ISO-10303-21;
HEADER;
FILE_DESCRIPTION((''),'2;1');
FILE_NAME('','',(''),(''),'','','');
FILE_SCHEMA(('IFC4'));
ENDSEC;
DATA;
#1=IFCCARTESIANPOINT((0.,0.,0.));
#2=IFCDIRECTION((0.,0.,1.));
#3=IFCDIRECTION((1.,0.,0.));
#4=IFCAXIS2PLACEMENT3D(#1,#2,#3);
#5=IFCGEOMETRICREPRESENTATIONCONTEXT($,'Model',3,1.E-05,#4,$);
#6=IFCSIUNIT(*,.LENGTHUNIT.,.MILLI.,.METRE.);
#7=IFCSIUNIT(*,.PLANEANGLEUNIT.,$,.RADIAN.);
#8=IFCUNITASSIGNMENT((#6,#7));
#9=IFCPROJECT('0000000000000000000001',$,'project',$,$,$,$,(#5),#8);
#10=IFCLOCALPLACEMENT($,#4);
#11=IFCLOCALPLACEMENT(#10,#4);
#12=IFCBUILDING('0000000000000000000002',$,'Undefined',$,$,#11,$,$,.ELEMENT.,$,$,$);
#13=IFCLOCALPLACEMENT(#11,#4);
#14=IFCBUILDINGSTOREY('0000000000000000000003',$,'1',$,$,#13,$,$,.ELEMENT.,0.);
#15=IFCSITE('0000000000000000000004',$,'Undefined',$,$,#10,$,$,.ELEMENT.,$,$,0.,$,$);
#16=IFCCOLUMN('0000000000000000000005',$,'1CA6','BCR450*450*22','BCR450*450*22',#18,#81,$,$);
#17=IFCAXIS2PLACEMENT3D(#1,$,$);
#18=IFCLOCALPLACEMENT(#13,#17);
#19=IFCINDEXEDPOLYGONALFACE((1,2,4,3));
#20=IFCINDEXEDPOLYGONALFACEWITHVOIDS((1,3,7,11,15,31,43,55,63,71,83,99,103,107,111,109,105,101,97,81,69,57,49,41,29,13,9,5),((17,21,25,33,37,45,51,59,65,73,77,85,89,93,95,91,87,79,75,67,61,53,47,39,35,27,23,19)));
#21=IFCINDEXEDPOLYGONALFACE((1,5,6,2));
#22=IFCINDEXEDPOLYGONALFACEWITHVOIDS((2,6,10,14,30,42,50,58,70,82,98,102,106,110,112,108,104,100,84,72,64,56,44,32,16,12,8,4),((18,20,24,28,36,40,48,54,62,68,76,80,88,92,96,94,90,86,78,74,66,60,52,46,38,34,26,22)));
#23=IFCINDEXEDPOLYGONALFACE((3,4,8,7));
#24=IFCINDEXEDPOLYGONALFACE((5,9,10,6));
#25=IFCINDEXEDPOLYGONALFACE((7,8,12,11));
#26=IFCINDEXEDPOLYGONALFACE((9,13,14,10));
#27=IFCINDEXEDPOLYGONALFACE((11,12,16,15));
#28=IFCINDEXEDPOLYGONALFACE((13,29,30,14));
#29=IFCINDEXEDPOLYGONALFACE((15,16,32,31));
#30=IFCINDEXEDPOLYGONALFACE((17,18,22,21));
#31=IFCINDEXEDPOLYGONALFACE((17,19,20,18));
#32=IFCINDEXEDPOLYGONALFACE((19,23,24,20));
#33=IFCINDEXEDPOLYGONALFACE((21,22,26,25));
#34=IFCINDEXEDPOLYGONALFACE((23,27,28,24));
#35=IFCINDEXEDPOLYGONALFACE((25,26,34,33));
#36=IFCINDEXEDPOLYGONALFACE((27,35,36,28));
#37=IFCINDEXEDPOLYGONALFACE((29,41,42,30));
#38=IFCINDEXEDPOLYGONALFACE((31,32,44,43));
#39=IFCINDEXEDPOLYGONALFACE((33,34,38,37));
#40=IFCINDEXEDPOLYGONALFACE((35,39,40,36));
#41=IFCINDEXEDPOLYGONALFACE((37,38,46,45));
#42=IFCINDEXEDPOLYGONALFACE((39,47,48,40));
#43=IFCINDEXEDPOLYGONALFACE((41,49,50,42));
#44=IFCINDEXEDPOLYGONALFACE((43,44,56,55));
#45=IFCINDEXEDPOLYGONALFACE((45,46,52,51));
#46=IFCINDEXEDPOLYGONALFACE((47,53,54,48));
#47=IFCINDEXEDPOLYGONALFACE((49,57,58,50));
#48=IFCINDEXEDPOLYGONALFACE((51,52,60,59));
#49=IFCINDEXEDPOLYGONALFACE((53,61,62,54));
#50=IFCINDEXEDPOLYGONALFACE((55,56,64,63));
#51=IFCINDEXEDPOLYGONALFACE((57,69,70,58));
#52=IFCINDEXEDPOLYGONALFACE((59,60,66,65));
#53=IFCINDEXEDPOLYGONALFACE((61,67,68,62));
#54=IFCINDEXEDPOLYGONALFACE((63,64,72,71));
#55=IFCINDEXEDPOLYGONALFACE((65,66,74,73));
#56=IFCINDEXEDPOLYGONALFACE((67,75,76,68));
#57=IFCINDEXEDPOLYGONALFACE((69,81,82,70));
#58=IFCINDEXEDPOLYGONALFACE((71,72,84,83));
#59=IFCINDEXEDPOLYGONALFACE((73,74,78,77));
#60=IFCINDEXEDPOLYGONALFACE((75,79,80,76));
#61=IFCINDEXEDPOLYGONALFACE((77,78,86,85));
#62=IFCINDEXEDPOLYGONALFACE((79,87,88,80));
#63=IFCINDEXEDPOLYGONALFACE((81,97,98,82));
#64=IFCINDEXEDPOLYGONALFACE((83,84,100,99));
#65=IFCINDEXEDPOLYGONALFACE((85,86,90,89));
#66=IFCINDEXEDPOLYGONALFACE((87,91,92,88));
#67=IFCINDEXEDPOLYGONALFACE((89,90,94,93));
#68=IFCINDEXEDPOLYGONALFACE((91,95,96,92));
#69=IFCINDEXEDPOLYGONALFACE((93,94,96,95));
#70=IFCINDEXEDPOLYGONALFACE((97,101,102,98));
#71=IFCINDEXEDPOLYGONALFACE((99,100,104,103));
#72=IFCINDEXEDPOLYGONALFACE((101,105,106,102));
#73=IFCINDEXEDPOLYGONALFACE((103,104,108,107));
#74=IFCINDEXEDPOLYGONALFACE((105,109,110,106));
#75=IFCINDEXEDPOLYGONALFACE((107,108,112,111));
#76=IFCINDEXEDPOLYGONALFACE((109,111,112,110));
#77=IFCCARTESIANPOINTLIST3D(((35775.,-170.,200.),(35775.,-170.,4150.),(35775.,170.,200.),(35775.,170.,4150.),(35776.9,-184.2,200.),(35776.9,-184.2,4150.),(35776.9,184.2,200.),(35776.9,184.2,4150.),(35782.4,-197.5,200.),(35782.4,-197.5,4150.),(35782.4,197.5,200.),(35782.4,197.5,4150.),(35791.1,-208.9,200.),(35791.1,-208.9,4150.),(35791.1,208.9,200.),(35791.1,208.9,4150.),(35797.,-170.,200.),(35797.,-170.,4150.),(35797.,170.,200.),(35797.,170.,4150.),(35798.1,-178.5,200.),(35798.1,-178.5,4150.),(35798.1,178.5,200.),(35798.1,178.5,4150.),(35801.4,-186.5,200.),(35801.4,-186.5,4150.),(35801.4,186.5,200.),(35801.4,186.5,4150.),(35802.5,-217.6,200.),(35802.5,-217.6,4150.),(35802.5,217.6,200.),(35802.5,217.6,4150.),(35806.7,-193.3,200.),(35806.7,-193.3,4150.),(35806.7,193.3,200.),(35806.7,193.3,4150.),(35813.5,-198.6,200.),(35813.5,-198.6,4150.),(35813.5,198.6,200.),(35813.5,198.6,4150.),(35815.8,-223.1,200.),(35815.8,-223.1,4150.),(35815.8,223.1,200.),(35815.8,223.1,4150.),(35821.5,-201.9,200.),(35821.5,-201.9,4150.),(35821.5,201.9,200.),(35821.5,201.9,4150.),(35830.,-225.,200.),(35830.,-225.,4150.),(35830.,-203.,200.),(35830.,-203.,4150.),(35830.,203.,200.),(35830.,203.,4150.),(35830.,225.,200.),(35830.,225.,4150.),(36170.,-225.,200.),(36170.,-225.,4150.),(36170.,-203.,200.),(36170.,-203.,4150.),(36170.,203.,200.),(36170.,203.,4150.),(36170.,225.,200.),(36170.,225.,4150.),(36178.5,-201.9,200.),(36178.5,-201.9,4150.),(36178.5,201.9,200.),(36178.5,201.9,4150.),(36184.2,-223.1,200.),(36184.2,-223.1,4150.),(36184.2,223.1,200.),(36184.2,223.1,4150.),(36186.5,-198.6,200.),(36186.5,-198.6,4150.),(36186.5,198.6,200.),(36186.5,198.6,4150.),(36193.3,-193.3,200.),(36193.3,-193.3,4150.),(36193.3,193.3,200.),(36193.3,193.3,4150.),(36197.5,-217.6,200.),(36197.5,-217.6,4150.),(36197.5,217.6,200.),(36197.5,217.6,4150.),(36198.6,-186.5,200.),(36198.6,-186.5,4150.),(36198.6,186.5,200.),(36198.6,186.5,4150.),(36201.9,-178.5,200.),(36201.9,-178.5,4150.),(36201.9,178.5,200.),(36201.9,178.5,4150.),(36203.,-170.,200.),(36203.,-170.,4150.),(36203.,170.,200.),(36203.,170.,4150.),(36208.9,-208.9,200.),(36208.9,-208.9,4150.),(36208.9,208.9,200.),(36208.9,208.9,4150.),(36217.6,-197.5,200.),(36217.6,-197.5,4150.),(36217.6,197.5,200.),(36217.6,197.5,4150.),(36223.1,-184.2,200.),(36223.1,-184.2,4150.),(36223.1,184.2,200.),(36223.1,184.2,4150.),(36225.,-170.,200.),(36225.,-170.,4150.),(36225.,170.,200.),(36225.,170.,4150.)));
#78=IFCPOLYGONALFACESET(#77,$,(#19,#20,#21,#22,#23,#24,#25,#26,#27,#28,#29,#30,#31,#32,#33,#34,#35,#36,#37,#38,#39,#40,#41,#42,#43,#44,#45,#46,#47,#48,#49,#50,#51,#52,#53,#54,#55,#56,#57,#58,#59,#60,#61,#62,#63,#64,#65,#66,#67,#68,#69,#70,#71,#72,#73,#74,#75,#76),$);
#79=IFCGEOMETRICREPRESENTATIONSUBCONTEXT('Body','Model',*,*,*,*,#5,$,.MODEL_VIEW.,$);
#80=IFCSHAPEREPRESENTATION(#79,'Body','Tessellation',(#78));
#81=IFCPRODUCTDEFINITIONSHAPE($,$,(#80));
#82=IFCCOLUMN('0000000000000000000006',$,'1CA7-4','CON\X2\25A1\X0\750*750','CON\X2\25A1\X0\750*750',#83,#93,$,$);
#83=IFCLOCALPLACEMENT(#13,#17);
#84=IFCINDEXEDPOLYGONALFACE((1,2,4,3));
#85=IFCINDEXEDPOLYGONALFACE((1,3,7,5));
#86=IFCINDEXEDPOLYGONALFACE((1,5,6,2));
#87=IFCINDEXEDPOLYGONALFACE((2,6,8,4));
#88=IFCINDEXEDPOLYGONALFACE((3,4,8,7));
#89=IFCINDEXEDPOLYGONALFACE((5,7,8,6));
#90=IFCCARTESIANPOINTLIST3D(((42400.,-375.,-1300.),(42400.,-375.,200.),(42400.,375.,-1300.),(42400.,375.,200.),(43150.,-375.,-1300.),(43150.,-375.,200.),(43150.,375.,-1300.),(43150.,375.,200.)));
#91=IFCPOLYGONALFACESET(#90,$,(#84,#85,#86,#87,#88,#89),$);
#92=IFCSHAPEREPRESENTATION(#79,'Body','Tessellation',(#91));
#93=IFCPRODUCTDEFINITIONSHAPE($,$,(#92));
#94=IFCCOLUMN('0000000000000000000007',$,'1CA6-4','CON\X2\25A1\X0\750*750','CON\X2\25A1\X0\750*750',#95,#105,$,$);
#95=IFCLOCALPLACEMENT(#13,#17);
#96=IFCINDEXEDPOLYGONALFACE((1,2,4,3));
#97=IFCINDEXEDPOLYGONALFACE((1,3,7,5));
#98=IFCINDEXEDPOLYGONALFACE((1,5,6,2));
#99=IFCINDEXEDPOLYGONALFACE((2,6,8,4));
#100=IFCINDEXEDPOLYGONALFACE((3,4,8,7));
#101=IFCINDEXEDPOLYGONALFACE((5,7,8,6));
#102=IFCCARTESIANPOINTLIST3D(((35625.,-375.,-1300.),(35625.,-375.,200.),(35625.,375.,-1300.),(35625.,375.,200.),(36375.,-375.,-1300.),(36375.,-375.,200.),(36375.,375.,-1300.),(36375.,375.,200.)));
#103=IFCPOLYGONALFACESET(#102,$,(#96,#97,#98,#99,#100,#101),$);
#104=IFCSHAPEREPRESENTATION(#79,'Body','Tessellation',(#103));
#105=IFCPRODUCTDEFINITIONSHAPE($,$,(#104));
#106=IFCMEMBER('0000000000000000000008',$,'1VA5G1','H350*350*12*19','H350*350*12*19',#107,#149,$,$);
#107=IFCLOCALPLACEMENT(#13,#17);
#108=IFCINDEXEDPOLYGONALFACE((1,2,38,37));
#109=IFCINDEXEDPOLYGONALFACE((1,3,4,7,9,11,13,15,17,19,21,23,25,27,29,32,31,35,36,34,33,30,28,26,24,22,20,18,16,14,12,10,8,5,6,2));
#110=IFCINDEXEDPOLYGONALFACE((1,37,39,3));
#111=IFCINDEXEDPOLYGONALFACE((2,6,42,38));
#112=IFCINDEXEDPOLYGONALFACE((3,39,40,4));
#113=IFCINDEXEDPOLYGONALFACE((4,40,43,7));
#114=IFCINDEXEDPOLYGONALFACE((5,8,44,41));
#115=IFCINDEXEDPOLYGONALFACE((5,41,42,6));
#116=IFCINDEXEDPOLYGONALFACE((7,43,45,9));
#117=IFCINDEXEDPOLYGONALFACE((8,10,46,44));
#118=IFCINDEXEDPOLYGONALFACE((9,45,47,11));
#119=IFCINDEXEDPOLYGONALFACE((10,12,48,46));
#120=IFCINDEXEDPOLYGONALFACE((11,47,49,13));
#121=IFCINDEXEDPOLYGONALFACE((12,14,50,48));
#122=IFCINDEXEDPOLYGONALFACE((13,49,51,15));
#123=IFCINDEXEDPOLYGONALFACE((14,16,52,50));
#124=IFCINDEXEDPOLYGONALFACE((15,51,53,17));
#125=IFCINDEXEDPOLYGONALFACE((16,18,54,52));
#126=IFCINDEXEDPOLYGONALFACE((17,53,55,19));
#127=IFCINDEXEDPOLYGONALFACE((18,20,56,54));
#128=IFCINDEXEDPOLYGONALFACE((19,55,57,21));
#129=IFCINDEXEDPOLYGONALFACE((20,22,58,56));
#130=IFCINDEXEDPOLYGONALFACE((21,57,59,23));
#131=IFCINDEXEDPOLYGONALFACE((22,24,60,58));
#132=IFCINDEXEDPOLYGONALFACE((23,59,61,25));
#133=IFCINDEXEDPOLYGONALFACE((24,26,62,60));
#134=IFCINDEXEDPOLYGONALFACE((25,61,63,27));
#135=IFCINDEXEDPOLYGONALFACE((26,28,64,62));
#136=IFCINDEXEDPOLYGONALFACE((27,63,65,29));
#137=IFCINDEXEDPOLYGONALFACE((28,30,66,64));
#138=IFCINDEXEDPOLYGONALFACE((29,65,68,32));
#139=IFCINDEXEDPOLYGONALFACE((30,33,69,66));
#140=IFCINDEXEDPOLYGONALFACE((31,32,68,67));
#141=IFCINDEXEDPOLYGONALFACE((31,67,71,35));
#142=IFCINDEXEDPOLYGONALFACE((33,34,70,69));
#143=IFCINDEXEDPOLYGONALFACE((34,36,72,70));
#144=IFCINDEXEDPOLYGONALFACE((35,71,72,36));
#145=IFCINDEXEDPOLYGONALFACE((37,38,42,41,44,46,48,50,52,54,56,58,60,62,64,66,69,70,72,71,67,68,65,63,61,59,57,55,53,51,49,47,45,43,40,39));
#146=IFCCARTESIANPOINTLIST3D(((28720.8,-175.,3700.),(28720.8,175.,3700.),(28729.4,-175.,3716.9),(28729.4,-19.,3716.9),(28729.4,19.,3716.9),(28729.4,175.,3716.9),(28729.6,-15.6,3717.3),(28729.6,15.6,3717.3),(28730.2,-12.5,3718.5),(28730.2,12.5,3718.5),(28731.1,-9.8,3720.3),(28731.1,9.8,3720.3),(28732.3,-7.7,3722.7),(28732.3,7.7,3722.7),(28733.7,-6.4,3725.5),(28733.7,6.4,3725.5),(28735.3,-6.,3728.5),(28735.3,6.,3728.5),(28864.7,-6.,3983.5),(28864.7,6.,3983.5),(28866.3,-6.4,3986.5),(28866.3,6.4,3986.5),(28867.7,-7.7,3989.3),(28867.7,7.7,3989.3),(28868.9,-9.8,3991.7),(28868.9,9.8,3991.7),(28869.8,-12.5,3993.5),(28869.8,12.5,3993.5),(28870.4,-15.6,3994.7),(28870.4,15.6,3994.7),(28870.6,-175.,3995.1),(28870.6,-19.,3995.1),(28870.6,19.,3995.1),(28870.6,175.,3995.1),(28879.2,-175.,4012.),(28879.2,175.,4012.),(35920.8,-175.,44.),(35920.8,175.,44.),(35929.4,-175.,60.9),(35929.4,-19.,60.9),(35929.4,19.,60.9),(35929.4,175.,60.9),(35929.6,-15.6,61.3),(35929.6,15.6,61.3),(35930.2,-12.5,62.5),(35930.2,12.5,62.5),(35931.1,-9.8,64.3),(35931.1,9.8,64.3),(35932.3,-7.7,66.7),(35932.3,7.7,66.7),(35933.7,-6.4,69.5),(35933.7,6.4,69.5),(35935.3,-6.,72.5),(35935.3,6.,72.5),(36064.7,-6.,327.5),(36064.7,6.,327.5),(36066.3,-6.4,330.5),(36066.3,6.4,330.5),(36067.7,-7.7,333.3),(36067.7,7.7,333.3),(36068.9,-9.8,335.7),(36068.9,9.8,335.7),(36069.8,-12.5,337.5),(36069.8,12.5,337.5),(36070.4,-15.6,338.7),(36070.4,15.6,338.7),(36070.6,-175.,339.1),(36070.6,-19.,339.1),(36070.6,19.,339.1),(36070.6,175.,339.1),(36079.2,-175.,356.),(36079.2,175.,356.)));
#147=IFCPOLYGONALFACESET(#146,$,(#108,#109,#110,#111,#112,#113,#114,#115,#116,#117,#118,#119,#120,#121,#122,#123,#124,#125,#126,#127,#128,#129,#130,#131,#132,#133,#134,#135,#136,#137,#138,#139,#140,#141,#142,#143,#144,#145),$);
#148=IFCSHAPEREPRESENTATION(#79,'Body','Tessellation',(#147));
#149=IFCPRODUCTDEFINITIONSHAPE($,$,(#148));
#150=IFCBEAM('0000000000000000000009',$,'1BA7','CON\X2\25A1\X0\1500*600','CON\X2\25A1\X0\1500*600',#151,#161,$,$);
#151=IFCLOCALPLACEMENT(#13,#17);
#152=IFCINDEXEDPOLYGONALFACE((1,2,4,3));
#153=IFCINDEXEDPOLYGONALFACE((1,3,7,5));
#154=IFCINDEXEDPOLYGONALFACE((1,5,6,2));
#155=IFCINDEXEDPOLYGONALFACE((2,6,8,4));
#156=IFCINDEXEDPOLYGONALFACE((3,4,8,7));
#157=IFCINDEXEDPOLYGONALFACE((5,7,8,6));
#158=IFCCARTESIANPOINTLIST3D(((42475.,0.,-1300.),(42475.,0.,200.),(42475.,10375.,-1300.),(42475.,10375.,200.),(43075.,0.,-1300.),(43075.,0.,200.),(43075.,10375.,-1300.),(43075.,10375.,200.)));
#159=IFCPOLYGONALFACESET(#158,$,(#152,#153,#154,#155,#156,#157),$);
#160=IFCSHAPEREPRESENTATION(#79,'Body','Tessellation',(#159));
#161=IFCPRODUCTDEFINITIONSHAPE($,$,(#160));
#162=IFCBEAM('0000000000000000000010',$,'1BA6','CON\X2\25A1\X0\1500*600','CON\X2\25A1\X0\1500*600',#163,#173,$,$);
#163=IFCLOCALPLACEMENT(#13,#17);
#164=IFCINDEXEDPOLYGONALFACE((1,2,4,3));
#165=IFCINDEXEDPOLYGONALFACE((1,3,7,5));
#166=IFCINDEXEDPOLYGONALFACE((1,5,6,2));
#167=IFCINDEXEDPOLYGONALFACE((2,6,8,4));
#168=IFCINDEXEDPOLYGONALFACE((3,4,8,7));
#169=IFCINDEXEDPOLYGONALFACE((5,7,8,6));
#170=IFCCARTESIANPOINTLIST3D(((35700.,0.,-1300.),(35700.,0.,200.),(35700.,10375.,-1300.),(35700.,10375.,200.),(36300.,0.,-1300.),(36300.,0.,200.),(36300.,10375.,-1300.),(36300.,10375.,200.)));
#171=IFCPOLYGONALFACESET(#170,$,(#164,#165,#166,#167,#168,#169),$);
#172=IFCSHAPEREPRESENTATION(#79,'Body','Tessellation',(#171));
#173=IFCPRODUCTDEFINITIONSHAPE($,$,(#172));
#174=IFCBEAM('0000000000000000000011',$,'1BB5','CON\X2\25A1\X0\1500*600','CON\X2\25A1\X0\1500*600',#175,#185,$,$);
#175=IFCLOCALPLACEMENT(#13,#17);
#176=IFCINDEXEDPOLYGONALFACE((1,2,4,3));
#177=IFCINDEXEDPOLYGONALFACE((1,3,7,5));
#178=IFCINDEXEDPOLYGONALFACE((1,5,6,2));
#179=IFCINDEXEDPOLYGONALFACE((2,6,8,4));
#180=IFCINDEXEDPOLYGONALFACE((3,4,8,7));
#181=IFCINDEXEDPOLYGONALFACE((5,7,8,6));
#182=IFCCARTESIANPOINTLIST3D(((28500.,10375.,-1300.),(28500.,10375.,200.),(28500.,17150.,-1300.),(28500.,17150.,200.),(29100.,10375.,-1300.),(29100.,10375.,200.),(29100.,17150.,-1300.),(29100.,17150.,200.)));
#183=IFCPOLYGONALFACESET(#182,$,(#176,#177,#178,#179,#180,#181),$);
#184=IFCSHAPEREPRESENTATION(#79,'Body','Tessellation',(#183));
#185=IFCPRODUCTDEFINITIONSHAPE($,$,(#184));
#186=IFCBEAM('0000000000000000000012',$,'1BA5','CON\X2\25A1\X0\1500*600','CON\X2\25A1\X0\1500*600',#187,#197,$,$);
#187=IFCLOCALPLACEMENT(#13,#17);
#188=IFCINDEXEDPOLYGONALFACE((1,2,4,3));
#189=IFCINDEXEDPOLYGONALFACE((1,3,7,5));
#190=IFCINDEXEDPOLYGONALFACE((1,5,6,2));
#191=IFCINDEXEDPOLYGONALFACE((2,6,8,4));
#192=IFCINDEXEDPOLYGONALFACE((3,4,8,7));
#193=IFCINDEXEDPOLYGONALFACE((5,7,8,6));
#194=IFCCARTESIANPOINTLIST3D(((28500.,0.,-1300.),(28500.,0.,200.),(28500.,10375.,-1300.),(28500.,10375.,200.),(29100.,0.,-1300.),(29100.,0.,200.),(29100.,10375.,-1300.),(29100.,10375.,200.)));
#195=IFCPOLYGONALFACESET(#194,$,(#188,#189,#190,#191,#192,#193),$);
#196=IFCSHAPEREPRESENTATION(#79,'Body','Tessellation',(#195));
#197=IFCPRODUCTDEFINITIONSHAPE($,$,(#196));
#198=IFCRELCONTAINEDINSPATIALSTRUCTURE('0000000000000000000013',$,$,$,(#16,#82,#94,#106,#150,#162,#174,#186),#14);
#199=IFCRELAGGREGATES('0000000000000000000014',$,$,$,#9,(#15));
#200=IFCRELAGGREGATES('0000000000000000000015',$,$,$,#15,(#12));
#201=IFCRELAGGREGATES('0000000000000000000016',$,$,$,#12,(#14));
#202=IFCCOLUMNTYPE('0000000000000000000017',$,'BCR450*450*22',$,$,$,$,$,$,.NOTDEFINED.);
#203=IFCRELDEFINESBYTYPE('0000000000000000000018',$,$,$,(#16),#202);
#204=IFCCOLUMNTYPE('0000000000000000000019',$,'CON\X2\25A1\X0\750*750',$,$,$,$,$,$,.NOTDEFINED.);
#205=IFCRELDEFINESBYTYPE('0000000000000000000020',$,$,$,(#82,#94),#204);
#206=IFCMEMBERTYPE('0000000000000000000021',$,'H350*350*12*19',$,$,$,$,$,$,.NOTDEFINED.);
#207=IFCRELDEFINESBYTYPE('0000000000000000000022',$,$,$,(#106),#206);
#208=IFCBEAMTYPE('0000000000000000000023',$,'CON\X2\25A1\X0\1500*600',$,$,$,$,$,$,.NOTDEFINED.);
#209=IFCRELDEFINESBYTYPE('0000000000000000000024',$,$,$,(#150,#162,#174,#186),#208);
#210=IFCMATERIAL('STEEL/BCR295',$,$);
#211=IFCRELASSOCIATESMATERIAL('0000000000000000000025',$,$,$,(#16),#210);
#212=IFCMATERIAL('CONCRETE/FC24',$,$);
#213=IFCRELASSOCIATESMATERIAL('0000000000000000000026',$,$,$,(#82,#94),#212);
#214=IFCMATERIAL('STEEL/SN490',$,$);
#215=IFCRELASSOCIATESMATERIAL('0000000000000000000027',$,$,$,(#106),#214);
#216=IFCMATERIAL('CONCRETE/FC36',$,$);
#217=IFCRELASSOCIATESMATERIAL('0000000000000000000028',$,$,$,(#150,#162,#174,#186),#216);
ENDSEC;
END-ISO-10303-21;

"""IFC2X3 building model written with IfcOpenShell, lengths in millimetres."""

from ifc_helpers import new_model, si_unit, frame, origin_with_axes, origin_2d_with_axis, place, context, subcontext, project, spatial, rectangle, hollow_rectangle, i_section, extrude, material, type_object, element, save


model = new_model("IFC2X3")

# Units and contexts
model_context = context("Model", 3, precision=1e-05, world=origin_with_axes())
body_context = subcontext(model_context, "Body", "Model", "MODEL_VIEW")
ifc_project = project(units=[si_unit("LENGTHUNIT", "METRE", prefix="MILLI"), si_unit("PLANEANGLEUNIT", "RADIAN")], contexts=[model_context])

# Site, building, storey
site_placement = place(None, origin_with_axes())
site = spatial("IfcSite", under=ifc_project, at=site_placement, Name="Undefined", CompositionType="ELEMENT", RefElevation=0.0)
building_placement = place(site_placement, origin_with_axes())
building = spatial("IfcBuilding", under=site, at=building_placement, Name="Undefined", CompositionType="ELEMENT")
storey_placement = place(building_placement, origin_with_axes())
storey = spatial("IfcBuildingStorey", under=building, at=storey_placement, Name="1", CompositionType="ELEMENT", Elevation=0.0)

# Shared definitions
ifc_material_1 = material(Name="CONCRETE/FC24")

# Columns
ifc_material_2 = material(Name="STEEL/SN490")
ifc_material_3 = material(Name="STEEL/BCR295")
column_type_1 = type_object("IfcColumnType", Name="BCR450*450*22", PredefinedType="NOTDEFINED")
for number, where, z_axis, x_axis, name in (
    (1, (36000.0, 0.0, 200.0), (0.0, 0.0, 1.0), (0.0, 1.0, 0.0), "1CA6"),
):
    element("IfcColumn", number, at=place(storey_placement, frame(where, z_axis=z_axis, x_axis=x_axis)), inside=storey, type_object=column_type_1, material=ifc_material_3, Name=name, Description="BCR450*450*22", ObjectType="BCR450*450*22", context=body_context, shape_type="SweptSolid", body=[
        extrude(hollow_rectangle(XDim=450.0, YDim=450.0, WallThickness=22.0, InnerFilletRadius=33.0, OuterFilletRadius=55.0, at=origin_2d_with_axis()), frame((0.0, 0.0, 3950.0), z_axis=(0.0, 0.0, -1.0), x_axis=(0.0, 1.0, 0.0)), (0.0, 0.0, 1.0), 3950.0),
    ])
column_type_2 = type_object("IfcColumnType", Name="CON□750*750", PredefinedType="NOTDEFINED")
for number, where, z_axis, x_axis, name in (
    (2, (42775.0, 0.0, -1300.0), (0.0, 0.0, 1.0), (0.0, 1.0, 0.0), "1CA7-4"),
    (3, (36000.0, 0.0, -1300.0), (0.0, 0.0, 1.0), (0.0, 1.0, 0.0), "1CA6-4"),
):
    element("IfcColumn", number, at=place(storey_placement, frame(where, z_axis=z_axis, x_axis=x_axis)), inside=storey, type_object=column_type_2, material=ifc_material_1, Name=name, Description="CON□750*750", ObjectType="CON□750*750", context=body_context, shape_type="SweptSolid", body=[
        extrude(rectangle(XDim=750.0, YDim=750.0, at=origin_2d_with_axis()), frame((0.0, 0.0, 1500.0), z_axis=(0.0, 0.0, -1.0), x_axis=(0.0, 1.0, 0.0)), (0.0, 0.0, 1.0), 1500.0),
    ])

# Member
member_type = type_object("IfcMemberType", Name="H350*350*12*19", PredefinedType="NOTDEFINED")
member_placement = place(storey_placement, frame((36000.0, 0.0, 200.0), z_axis=(0.452753, 0.0, 0.891636), x_axis=(-0.891636, 0.0, 0.452753)))
element("IfcMember", 4, at=member_placement, inside=storey, type_object=member_type, material=ifc_material_2, Name="1VA5G1", Description="H350*350*12*19", ObjectType="H350*350*12*19", context=body_context, shape_type="SweptSolid", body=[
    extrude(i_section(OverallWidth=350.0, OverallDepth=350.0, WebThickness=12.0, FlangeThickness=19.0, FilletRadius=13.0, at=origin_2d_with_axis()), frame((8075.0, 0.0, 0.0), z_axis=(-1.0, 0.0, 0.0), x_axis=(0.0, -1.0, 0.0)), (0.0, 0.0, 1.0), 8075.0),
])

# Beams
ifc_material_4 = material(Name="CONCRETE/FC36")
beam_type_1 = type_object("IfcBeamType", Name="CON□1500*600", PredefinedType="NOTDEFINED")
for number, where, z_axis, x_axis, name in (
    (5, (42775.0, 0.0, -550.0), (0.0, 0.0, 1.0), (0.0, 1.0, 0.0), "1BA7"),
    (6, (36000.0, 0.0, -550.0), (0.0, 0.0, 1.0), (0.0, 1.0, 0.0), "1BA6"),
):
    element("IfcBeam", number, at=place(storey_placement, frame(where, z_axis=z_axis, x_axis=x_axis)), inside=storey, type_object=beam_type_1, material=ifc_material_4, Name=name, Description="CON□1500*600", ObjectType="CON□1500*600", context=body_context, shape_type="SweptSolid", body=[
        extrude(rectangle(XDim=600.0, YDim=1500.0, at=origin_2d_with_axis()), frame((10375.0, 0.0, 0.0), z_axis=(-1.0, 0.0, 0.0), x_axis=(0.0, -1.0, 0.0)), (0.0, 0.0, 1.0), 10375.0),
    ])
beam_1_placement = place(storey_placement, frame((28800.0, 10375.0, -550.0), z_axis=(0.0, 0.0, 1.0), x_axis=(0.0, 1.0, 0.0)))
element("IfcBeam", 7, at=beam_1_placement, inside=storey, type_object=beam_type_1, material=ifc_material_4, Name="1BB5", Description="CON□1500*600", ObjectType="CON□1500*600", context=body_context, shape_type="SweptSolid", body=[
    extrude(rectangle(XDim=600.0, YDim=1500.0, at=origin_2d_with_axis()), frame((6775.0, 0.0, 0.0), z_axis=(-1.0, 0.0, 0.0), x_axis=(0.0, -1.0, 0.0)), (0.0, 0.0, 1.0), 6775.0),
])
beam_2_placement = place(storey_placement, frame((28800.0, 0.0, -550.0), z_axis=(0.0, 0.0, 1.0), x_axis=(0.0, 1.0, 0.0)))
element("IfcBeam", 8, at=beam_2_placement, inside=storey, type_object=beam_type_1, material=ifc_material_4, Name="1BA5", Description="CON□1500*600", ObjectType="CON□1500*600", context=body_context, shape_type="SweptSolid", body=[
    extrude(rectangle(XDim=600.0, YDim=1500.0, at=origin_2d_with_axis()), frame((10375.0, 0.0, 0.0), z_axis=(-1.0, 0.0, 0.0), x_axis=(0.0, -1.0, 0.0)), (0.0, 0.0, 1.0), 10375.0),
])

save(model, "model.ifc")
